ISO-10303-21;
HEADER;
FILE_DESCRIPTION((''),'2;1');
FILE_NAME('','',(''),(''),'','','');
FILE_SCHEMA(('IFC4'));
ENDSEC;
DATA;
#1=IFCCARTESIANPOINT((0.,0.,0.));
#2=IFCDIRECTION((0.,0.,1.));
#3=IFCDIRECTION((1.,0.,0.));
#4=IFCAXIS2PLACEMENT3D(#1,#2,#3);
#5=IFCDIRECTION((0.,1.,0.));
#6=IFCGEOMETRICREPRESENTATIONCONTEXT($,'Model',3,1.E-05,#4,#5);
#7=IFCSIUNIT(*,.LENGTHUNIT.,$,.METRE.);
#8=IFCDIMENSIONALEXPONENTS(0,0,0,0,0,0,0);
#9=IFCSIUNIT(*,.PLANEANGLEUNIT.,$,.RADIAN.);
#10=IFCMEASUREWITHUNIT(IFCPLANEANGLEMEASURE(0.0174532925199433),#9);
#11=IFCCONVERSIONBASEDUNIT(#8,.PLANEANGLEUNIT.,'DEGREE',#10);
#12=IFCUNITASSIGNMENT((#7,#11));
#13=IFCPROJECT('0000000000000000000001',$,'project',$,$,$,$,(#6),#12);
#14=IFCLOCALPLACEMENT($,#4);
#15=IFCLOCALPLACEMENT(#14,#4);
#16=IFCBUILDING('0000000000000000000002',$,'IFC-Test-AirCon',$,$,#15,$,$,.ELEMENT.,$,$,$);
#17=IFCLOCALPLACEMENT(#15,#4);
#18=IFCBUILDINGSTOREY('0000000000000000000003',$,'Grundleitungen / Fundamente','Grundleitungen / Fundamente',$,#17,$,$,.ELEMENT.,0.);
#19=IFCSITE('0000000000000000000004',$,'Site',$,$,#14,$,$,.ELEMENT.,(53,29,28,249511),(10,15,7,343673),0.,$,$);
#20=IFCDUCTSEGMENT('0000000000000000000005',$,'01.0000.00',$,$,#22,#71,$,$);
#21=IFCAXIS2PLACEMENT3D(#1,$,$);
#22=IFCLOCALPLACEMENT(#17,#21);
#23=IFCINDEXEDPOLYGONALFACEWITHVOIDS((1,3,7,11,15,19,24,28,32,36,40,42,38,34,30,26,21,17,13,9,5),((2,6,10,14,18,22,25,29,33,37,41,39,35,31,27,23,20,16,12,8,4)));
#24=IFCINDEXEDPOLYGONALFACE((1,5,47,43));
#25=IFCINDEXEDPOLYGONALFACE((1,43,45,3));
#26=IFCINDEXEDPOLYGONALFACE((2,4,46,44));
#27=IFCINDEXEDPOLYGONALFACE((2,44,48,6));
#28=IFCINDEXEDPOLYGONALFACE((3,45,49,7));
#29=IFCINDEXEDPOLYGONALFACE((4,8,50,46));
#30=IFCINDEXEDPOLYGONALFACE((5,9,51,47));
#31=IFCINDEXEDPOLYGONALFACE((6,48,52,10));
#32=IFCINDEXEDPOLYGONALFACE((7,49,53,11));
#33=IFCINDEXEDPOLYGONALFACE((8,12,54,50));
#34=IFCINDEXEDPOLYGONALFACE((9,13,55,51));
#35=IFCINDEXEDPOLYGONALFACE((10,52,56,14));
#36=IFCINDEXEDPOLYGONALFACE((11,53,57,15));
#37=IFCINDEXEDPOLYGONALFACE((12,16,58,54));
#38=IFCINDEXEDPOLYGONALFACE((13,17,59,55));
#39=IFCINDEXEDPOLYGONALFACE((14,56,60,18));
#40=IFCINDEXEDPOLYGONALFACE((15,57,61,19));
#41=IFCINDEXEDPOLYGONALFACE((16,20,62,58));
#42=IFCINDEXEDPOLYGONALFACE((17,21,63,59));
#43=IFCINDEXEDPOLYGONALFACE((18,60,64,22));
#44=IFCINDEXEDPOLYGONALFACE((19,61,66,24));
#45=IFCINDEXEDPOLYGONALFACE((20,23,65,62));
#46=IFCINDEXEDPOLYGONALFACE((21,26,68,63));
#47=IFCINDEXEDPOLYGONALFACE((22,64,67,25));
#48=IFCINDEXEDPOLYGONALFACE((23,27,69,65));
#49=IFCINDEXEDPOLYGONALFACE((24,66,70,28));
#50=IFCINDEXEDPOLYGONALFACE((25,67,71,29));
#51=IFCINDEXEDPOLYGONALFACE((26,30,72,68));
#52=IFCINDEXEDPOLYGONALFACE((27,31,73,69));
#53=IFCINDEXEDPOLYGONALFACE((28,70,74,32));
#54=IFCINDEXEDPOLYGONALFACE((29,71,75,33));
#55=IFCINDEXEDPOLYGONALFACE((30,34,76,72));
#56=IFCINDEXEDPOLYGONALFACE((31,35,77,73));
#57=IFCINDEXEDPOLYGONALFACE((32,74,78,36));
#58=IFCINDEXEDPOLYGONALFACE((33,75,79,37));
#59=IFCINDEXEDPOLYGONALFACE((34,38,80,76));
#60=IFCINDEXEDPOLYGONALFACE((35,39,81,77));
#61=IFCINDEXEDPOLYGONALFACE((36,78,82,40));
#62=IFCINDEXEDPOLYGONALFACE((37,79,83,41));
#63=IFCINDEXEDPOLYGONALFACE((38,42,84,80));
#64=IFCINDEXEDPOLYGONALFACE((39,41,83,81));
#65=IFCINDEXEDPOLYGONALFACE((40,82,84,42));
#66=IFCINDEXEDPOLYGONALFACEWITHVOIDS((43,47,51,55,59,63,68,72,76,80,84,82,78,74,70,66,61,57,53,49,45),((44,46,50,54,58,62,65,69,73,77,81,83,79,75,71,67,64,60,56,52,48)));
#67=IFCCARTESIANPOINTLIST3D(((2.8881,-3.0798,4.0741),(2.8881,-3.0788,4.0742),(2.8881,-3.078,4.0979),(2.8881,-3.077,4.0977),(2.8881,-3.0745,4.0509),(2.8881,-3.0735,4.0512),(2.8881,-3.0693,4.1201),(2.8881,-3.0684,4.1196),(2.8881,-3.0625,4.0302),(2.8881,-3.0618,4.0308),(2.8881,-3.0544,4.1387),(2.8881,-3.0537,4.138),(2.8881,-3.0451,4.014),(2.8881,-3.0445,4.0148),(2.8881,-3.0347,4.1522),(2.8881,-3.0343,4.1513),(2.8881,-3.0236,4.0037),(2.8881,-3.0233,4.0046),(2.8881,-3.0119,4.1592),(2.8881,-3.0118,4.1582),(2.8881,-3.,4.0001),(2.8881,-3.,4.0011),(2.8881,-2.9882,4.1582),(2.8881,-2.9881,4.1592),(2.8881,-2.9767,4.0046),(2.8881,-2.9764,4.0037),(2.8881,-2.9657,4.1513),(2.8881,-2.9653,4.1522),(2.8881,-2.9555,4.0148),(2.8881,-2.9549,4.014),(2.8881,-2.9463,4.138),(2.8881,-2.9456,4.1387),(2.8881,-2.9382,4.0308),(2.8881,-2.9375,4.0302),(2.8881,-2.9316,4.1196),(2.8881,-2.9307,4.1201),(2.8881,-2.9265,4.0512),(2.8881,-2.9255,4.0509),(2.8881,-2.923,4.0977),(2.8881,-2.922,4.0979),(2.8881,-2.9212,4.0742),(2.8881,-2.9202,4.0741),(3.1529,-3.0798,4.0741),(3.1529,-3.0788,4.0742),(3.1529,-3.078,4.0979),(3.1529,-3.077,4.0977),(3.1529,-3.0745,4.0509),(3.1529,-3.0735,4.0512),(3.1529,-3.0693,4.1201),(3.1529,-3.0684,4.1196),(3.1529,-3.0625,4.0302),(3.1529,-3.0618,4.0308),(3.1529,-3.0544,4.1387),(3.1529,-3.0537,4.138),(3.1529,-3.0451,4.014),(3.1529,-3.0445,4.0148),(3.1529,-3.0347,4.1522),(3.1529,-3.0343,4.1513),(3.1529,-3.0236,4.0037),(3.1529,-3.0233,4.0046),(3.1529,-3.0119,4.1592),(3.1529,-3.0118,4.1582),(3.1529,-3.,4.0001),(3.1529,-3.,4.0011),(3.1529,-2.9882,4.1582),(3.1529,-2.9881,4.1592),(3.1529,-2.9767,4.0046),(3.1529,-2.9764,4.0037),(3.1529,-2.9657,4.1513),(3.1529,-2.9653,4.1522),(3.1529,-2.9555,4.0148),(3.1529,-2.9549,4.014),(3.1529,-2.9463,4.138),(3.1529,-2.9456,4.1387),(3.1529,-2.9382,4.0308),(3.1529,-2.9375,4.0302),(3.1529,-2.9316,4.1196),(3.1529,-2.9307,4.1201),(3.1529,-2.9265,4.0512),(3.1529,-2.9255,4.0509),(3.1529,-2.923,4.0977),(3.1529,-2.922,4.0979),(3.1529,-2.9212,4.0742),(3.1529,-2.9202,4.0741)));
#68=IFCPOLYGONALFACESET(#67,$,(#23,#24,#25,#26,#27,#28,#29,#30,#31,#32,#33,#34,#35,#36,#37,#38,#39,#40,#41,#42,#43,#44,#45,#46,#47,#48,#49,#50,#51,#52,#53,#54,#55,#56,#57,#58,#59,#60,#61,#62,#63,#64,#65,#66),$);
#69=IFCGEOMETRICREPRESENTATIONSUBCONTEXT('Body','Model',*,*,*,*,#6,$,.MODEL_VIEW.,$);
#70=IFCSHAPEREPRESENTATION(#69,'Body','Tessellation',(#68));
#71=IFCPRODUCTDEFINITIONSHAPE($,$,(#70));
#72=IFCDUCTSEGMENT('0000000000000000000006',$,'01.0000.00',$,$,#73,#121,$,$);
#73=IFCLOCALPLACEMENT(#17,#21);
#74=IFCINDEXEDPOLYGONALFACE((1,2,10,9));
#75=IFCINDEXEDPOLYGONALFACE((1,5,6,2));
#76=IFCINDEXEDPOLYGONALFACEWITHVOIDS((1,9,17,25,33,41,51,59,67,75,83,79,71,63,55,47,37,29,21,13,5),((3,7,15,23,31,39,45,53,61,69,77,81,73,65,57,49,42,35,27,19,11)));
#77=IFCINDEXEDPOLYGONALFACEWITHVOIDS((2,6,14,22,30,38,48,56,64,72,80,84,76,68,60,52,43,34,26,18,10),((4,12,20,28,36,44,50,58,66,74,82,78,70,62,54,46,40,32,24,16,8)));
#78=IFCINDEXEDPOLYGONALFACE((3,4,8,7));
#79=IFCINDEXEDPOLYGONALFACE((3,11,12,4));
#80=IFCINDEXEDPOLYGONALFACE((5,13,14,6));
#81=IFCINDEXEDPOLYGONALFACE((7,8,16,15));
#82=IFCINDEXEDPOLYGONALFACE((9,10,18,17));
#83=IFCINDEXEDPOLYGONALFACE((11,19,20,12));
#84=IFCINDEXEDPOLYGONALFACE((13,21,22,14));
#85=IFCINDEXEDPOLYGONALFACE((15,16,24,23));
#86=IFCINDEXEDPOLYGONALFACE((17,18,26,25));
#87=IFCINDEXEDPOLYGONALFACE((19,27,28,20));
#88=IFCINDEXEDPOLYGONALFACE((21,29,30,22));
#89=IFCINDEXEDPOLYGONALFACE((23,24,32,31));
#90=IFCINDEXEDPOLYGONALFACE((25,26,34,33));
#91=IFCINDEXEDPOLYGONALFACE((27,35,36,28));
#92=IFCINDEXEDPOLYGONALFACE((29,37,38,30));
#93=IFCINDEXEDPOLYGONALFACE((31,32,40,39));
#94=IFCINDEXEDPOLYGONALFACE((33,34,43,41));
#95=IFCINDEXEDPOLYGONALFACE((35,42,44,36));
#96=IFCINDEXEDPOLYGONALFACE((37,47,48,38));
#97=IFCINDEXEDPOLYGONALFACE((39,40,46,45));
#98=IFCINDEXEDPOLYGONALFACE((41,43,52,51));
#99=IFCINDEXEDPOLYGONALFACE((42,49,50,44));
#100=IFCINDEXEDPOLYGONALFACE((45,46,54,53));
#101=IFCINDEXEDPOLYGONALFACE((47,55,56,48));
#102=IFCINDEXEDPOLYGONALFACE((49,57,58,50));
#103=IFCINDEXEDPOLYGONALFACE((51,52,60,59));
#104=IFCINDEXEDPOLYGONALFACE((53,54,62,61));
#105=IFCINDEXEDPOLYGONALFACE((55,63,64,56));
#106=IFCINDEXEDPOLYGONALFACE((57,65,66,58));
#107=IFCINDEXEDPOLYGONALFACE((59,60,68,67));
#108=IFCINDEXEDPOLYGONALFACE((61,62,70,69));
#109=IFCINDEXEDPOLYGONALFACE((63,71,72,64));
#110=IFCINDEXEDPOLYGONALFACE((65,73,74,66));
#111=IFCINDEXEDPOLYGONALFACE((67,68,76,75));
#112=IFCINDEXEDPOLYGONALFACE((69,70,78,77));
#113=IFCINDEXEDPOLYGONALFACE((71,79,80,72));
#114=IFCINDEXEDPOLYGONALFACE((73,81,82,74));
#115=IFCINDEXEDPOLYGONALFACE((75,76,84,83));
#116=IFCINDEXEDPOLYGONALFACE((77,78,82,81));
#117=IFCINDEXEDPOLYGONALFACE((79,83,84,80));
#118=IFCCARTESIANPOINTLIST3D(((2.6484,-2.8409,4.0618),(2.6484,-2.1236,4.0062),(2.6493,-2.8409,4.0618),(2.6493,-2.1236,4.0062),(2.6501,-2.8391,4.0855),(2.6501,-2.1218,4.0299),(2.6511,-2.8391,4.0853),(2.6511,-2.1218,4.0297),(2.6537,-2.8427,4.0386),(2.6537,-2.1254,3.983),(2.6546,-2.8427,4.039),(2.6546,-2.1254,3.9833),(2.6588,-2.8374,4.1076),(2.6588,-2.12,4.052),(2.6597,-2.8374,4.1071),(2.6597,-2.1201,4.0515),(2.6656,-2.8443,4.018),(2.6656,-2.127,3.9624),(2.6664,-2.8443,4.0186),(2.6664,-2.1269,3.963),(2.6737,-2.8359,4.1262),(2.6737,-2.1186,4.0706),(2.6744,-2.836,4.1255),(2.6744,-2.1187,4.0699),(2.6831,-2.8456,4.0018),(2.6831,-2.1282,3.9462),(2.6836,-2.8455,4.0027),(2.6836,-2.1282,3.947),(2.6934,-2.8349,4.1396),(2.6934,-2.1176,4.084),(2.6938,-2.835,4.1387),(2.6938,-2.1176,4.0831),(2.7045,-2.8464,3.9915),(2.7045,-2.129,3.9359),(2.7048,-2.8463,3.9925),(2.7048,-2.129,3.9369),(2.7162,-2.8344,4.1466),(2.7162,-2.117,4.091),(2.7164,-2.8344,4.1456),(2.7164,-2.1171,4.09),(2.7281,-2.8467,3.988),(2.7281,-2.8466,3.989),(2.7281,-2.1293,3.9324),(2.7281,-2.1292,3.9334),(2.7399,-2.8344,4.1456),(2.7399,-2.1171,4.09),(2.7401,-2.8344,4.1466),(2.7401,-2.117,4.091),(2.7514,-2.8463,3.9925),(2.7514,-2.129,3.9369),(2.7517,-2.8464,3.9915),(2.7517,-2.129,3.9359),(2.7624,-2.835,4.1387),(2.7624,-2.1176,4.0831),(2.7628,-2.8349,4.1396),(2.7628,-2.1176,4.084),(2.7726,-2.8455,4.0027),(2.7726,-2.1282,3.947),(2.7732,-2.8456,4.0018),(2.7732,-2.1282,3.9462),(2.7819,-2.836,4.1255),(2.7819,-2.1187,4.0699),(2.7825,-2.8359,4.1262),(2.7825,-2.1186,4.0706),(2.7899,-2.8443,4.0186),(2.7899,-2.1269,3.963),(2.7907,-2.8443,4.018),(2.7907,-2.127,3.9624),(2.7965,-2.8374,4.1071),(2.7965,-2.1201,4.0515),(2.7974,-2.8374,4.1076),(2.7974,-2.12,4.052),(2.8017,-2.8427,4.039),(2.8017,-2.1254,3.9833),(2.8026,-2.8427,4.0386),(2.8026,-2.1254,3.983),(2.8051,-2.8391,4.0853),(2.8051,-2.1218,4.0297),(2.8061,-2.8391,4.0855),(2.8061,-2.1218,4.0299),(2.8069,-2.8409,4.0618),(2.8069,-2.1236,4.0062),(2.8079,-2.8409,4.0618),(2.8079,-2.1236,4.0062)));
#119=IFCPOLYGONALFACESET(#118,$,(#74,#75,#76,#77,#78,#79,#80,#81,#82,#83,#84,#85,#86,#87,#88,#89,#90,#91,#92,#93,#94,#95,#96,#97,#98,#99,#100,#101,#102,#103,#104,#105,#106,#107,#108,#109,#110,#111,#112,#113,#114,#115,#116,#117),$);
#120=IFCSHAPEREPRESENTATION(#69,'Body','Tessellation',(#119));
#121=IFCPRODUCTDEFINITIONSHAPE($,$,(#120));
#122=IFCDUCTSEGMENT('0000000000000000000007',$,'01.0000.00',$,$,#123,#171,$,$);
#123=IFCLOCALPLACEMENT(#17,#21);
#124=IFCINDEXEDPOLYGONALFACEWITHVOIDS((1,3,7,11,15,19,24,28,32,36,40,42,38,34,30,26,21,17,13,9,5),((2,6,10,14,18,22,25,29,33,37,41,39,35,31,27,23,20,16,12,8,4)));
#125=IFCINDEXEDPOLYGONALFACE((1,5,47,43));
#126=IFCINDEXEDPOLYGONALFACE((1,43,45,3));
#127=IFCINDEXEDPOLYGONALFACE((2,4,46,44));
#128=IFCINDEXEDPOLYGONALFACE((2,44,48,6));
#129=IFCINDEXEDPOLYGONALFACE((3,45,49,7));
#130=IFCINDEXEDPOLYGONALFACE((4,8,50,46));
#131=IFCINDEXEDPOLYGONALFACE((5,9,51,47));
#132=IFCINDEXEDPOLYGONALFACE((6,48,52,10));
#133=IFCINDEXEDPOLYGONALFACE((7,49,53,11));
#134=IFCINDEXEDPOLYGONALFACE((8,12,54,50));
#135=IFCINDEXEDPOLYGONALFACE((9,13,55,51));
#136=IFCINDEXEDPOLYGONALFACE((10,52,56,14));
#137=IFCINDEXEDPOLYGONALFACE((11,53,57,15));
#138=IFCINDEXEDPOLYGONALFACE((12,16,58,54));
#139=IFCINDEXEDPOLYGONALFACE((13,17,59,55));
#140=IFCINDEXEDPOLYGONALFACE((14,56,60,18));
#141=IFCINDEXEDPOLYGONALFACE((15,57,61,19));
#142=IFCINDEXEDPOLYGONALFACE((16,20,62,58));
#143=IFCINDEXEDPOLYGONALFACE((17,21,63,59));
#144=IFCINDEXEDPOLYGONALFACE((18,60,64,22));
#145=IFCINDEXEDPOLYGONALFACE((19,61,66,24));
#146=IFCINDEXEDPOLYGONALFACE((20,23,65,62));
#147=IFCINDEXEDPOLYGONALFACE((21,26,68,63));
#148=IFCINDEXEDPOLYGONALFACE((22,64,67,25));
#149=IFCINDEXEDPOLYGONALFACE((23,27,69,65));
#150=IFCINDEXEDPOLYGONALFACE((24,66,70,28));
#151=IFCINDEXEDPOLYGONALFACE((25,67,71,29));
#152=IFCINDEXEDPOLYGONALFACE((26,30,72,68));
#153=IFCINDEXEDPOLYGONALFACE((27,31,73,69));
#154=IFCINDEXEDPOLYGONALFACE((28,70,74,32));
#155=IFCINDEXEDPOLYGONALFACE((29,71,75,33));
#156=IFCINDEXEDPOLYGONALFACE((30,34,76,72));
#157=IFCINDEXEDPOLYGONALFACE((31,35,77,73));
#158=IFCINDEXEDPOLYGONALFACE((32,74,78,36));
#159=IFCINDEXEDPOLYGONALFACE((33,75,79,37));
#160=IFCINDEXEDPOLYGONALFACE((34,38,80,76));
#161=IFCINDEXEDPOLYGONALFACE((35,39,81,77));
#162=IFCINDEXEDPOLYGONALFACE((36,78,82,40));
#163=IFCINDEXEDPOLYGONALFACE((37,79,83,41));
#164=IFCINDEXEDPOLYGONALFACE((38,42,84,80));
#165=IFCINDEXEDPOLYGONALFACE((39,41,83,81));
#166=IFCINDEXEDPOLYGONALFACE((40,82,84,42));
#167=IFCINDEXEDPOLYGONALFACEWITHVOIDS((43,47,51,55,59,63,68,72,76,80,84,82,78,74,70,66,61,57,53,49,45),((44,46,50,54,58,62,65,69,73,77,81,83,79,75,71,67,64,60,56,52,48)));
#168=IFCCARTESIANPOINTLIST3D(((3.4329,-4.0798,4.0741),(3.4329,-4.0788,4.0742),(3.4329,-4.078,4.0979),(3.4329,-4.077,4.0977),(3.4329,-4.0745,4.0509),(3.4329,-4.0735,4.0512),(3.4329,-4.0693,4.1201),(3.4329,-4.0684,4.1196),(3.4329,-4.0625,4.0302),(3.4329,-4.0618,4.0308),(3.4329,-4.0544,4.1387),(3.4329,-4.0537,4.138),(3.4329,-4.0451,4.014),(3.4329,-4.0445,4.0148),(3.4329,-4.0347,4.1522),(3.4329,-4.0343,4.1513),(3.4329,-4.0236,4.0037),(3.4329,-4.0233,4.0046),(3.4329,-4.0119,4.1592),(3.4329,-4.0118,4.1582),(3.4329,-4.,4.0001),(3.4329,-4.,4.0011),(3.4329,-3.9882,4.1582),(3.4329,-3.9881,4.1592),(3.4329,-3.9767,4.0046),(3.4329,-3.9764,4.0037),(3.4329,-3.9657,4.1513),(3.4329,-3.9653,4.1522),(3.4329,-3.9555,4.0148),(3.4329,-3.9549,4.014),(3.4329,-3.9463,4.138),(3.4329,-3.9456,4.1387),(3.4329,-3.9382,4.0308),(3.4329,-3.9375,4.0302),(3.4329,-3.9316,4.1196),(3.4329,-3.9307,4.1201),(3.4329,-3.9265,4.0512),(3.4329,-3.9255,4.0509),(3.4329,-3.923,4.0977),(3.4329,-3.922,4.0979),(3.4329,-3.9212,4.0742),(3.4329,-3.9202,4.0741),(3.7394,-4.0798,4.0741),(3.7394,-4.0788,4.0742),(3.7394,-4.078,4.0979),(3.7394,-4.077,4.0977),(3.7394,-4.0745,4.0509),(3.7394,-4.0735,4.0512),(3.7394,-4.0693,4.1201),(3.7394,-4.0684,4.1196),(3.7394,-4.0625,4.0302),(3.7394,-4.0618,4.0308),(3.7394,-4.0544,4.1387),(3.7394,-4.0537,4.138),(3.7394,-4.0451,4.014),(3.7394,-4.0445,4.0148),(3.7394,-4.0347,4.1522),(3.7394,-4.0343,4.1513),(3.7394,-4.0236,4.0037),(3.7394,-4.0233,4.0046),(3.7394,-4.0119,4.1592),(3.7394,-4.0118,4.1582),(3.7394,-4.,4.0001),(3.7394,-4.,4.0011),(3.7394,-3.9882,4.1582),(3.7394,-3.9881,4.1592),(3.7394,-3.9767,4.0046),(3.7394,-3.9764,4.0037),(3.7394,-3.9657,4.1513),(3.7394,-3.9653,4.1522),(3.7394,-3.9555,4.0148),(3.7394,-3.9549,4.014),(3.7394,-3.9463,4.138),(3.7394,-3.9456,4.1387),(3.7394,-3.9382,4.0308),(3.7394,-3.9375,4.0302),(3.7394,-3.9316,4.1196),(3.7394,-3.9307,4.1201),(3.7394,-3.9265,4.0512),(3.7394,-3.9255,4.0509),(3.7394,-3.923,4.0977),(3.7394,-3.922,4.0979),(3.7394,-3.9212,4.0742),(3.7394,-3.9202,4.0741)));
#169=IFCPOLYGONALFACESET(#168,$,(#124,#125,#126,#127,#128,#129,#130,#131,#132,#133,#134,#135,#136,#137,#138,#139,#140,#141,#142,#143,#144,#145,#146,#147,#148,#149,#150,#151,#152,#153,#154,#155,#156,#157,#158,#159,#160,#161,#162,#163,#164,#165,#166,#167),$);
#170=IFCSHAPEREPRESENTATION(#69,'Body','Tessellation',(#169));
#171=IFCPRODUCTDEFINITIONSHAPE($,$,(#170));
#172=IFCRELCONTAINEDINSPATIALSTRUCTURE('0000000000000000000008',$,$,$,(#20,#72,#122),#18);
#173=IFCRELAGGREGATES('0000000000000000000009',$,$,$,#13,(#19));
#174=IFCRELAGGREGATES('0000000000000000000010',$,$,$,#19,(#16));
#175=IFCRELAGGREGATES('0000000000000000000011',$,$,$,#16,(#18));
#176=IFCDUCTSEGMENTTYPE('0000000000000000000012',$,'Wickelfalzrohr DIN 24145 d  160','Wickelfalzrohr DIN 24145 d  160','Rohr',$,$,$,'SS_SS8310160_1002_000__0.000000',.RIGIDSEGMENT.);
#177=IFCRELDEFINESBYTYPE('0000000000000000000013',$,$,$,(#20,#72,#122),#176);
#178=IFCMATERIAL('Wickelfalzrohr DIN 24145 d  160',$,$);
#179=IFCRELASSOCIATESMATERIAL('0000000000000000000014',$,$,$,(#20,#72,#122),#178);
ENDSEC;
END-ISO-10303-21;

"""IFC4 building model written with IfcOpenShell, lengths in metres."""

from ifc_helpers import new_model, entity, si_unit, converted_unit, direction, frame, origin_with_axes, origin_2d_with_axis, place, context, subcontext, project, spatial, hollow_circle, extrude, material, type_object, element, save


model = new_model("IFC4")

# Units and contexts
model_context = context("Model", 3, precision=1e-05, world=origin_with_axes(), true_north=direction((0.0, 1.0, 0.0)))
body_context = subcontext(model_context, "Body", "Model", "MODEL_VIEW")
ifc_project = project(units=[si_unit("LENGTHUNIT", "METRE"), converted_unit("PLANEANGLEUNIT", "DEGREE", entity("IfcPlaneAngleMeasure", 0.0174532925199433), si_unit("PLANEANGLEUNIT", "RADIAN"), dimensions=[0, 0, 0, 0, 0, 0, 0])], contexts=[model_context])

# Site, building, storey
site_placement = place(None, origin_with_axes())
site = spatial("IfcSite", under=ifc_project, at=site_placement, Name="Site", CompositionType="ELEMENT", RefLatitude=(53, 29, 28, 249511), RefLongitude=(10, 15, 7, 343673), RefElevation=0.0)
building_placement = place(site_placement, origin_with_axes())
building = spatial("IfcBuilding", under=site, at=building_placement, Name="IFC-Test-AirCon", CompositionType="ELEMENT")
storey_placement = place(building_placement, origin_with_axes())
storey = spatial("IfcBuildingStorey", under=building, at=storey_placement, Name="Grundleitungen / Fundamente", Description="Grundleitungen / Fundamente", CompositionType="ELEMENT", Elevation=0.0)

# Duct segments
ifc_material_1 = material(Name="Wickelfalzrohr DIN 24145 d  160")
duct_segment_type_1 = type_object("IfcDuctSegmentType", Name="Wickelfalzrohr DIN 24145 d  160", Description="Wickelfalzrohr DIN 24145 d  160", ApplicableOccurrence="Rohr", ElementType="SS_SS8310160_1002_000__0.000000", PredefinedType="RIGIDSEGMENT")
duct_segment_1_placement = place(storey_placement, frame((3.1529, -3.0, 4.0801), z_axis=(0.0, 0.0, 1.0), x_axis=(-1.0, 0.0, 0.0)))
element("IfcDuctSegment", 1, at=duct_segment_1_placement, inside=storey, type_object=duct_segment_type_1, material=ifc_material_1, Name="01.0000.00", context=body_context, shape_type="SweptSolid", body=[
    extrude(hollow_circle(Radius=0.08, WallThickness=0.001, at=origin_2d_with_axis()), frame((0.0, 0.0, 0.0), z_axis=(1.0, 0.0, 0.0), x_axis=(0.0, 0.0, -1.0)), (0.0, 0.0, 1.0), 0.2648),
])
duct_segment_2_placement = place(storey_placement, frame((2.7281, -2.8405, 4.0677), z_axis=(0.0, 0.077291, 0.997009), x_axis=(0.0, 0.997009, -0.077291)))
element("IfcDuctSegment", 2, at=duct_segment_2_placement, inside=storey, type_object=duct_segment_type_1, material=ifc_material_1, Name="01.0000.00", context=body_context, shape_type="SweptSolid", body=[
    extrude(hollow_circle(Radius=0.08, WallThickness=0.001, at=origin_2d_with_axis()), frame((0.0, 0.0, 0.0), z_axis=(1.0, 0.0, 0.0), x_axis=(0.0, 0.0, -1.0)), (0.0, 0.0, 1.0), 0.7195),
])
duct_segment_3_placement = place(storey_placement, frame((3.7394, -4.0, 4.0801), z_axis=(0.0, 0.0, 1.0), x_axis=(-1.0, 0.0, 0.0)))
element("IfcDuctSegment", 3, at=duct_segment_3_placement, inside=storey, type_object=duct_segment_type_1, material=ifc_material_1, Name="01.0000.00", context=body_context, shape_type="SweptSolid", body=[
    extrude(hollow_circle(Radius=0.08, WallThickness=0.001, at=origin_2d_with_axis()), frame((0.0, 0.0, 0.0), z_axis=(1.0, 0.0, 0.0), x_axis=(0.0, 0.0, -1.0)), (0.0, 0.0, 1.0), 0.3065),
])

save(model, "model.ifc")
